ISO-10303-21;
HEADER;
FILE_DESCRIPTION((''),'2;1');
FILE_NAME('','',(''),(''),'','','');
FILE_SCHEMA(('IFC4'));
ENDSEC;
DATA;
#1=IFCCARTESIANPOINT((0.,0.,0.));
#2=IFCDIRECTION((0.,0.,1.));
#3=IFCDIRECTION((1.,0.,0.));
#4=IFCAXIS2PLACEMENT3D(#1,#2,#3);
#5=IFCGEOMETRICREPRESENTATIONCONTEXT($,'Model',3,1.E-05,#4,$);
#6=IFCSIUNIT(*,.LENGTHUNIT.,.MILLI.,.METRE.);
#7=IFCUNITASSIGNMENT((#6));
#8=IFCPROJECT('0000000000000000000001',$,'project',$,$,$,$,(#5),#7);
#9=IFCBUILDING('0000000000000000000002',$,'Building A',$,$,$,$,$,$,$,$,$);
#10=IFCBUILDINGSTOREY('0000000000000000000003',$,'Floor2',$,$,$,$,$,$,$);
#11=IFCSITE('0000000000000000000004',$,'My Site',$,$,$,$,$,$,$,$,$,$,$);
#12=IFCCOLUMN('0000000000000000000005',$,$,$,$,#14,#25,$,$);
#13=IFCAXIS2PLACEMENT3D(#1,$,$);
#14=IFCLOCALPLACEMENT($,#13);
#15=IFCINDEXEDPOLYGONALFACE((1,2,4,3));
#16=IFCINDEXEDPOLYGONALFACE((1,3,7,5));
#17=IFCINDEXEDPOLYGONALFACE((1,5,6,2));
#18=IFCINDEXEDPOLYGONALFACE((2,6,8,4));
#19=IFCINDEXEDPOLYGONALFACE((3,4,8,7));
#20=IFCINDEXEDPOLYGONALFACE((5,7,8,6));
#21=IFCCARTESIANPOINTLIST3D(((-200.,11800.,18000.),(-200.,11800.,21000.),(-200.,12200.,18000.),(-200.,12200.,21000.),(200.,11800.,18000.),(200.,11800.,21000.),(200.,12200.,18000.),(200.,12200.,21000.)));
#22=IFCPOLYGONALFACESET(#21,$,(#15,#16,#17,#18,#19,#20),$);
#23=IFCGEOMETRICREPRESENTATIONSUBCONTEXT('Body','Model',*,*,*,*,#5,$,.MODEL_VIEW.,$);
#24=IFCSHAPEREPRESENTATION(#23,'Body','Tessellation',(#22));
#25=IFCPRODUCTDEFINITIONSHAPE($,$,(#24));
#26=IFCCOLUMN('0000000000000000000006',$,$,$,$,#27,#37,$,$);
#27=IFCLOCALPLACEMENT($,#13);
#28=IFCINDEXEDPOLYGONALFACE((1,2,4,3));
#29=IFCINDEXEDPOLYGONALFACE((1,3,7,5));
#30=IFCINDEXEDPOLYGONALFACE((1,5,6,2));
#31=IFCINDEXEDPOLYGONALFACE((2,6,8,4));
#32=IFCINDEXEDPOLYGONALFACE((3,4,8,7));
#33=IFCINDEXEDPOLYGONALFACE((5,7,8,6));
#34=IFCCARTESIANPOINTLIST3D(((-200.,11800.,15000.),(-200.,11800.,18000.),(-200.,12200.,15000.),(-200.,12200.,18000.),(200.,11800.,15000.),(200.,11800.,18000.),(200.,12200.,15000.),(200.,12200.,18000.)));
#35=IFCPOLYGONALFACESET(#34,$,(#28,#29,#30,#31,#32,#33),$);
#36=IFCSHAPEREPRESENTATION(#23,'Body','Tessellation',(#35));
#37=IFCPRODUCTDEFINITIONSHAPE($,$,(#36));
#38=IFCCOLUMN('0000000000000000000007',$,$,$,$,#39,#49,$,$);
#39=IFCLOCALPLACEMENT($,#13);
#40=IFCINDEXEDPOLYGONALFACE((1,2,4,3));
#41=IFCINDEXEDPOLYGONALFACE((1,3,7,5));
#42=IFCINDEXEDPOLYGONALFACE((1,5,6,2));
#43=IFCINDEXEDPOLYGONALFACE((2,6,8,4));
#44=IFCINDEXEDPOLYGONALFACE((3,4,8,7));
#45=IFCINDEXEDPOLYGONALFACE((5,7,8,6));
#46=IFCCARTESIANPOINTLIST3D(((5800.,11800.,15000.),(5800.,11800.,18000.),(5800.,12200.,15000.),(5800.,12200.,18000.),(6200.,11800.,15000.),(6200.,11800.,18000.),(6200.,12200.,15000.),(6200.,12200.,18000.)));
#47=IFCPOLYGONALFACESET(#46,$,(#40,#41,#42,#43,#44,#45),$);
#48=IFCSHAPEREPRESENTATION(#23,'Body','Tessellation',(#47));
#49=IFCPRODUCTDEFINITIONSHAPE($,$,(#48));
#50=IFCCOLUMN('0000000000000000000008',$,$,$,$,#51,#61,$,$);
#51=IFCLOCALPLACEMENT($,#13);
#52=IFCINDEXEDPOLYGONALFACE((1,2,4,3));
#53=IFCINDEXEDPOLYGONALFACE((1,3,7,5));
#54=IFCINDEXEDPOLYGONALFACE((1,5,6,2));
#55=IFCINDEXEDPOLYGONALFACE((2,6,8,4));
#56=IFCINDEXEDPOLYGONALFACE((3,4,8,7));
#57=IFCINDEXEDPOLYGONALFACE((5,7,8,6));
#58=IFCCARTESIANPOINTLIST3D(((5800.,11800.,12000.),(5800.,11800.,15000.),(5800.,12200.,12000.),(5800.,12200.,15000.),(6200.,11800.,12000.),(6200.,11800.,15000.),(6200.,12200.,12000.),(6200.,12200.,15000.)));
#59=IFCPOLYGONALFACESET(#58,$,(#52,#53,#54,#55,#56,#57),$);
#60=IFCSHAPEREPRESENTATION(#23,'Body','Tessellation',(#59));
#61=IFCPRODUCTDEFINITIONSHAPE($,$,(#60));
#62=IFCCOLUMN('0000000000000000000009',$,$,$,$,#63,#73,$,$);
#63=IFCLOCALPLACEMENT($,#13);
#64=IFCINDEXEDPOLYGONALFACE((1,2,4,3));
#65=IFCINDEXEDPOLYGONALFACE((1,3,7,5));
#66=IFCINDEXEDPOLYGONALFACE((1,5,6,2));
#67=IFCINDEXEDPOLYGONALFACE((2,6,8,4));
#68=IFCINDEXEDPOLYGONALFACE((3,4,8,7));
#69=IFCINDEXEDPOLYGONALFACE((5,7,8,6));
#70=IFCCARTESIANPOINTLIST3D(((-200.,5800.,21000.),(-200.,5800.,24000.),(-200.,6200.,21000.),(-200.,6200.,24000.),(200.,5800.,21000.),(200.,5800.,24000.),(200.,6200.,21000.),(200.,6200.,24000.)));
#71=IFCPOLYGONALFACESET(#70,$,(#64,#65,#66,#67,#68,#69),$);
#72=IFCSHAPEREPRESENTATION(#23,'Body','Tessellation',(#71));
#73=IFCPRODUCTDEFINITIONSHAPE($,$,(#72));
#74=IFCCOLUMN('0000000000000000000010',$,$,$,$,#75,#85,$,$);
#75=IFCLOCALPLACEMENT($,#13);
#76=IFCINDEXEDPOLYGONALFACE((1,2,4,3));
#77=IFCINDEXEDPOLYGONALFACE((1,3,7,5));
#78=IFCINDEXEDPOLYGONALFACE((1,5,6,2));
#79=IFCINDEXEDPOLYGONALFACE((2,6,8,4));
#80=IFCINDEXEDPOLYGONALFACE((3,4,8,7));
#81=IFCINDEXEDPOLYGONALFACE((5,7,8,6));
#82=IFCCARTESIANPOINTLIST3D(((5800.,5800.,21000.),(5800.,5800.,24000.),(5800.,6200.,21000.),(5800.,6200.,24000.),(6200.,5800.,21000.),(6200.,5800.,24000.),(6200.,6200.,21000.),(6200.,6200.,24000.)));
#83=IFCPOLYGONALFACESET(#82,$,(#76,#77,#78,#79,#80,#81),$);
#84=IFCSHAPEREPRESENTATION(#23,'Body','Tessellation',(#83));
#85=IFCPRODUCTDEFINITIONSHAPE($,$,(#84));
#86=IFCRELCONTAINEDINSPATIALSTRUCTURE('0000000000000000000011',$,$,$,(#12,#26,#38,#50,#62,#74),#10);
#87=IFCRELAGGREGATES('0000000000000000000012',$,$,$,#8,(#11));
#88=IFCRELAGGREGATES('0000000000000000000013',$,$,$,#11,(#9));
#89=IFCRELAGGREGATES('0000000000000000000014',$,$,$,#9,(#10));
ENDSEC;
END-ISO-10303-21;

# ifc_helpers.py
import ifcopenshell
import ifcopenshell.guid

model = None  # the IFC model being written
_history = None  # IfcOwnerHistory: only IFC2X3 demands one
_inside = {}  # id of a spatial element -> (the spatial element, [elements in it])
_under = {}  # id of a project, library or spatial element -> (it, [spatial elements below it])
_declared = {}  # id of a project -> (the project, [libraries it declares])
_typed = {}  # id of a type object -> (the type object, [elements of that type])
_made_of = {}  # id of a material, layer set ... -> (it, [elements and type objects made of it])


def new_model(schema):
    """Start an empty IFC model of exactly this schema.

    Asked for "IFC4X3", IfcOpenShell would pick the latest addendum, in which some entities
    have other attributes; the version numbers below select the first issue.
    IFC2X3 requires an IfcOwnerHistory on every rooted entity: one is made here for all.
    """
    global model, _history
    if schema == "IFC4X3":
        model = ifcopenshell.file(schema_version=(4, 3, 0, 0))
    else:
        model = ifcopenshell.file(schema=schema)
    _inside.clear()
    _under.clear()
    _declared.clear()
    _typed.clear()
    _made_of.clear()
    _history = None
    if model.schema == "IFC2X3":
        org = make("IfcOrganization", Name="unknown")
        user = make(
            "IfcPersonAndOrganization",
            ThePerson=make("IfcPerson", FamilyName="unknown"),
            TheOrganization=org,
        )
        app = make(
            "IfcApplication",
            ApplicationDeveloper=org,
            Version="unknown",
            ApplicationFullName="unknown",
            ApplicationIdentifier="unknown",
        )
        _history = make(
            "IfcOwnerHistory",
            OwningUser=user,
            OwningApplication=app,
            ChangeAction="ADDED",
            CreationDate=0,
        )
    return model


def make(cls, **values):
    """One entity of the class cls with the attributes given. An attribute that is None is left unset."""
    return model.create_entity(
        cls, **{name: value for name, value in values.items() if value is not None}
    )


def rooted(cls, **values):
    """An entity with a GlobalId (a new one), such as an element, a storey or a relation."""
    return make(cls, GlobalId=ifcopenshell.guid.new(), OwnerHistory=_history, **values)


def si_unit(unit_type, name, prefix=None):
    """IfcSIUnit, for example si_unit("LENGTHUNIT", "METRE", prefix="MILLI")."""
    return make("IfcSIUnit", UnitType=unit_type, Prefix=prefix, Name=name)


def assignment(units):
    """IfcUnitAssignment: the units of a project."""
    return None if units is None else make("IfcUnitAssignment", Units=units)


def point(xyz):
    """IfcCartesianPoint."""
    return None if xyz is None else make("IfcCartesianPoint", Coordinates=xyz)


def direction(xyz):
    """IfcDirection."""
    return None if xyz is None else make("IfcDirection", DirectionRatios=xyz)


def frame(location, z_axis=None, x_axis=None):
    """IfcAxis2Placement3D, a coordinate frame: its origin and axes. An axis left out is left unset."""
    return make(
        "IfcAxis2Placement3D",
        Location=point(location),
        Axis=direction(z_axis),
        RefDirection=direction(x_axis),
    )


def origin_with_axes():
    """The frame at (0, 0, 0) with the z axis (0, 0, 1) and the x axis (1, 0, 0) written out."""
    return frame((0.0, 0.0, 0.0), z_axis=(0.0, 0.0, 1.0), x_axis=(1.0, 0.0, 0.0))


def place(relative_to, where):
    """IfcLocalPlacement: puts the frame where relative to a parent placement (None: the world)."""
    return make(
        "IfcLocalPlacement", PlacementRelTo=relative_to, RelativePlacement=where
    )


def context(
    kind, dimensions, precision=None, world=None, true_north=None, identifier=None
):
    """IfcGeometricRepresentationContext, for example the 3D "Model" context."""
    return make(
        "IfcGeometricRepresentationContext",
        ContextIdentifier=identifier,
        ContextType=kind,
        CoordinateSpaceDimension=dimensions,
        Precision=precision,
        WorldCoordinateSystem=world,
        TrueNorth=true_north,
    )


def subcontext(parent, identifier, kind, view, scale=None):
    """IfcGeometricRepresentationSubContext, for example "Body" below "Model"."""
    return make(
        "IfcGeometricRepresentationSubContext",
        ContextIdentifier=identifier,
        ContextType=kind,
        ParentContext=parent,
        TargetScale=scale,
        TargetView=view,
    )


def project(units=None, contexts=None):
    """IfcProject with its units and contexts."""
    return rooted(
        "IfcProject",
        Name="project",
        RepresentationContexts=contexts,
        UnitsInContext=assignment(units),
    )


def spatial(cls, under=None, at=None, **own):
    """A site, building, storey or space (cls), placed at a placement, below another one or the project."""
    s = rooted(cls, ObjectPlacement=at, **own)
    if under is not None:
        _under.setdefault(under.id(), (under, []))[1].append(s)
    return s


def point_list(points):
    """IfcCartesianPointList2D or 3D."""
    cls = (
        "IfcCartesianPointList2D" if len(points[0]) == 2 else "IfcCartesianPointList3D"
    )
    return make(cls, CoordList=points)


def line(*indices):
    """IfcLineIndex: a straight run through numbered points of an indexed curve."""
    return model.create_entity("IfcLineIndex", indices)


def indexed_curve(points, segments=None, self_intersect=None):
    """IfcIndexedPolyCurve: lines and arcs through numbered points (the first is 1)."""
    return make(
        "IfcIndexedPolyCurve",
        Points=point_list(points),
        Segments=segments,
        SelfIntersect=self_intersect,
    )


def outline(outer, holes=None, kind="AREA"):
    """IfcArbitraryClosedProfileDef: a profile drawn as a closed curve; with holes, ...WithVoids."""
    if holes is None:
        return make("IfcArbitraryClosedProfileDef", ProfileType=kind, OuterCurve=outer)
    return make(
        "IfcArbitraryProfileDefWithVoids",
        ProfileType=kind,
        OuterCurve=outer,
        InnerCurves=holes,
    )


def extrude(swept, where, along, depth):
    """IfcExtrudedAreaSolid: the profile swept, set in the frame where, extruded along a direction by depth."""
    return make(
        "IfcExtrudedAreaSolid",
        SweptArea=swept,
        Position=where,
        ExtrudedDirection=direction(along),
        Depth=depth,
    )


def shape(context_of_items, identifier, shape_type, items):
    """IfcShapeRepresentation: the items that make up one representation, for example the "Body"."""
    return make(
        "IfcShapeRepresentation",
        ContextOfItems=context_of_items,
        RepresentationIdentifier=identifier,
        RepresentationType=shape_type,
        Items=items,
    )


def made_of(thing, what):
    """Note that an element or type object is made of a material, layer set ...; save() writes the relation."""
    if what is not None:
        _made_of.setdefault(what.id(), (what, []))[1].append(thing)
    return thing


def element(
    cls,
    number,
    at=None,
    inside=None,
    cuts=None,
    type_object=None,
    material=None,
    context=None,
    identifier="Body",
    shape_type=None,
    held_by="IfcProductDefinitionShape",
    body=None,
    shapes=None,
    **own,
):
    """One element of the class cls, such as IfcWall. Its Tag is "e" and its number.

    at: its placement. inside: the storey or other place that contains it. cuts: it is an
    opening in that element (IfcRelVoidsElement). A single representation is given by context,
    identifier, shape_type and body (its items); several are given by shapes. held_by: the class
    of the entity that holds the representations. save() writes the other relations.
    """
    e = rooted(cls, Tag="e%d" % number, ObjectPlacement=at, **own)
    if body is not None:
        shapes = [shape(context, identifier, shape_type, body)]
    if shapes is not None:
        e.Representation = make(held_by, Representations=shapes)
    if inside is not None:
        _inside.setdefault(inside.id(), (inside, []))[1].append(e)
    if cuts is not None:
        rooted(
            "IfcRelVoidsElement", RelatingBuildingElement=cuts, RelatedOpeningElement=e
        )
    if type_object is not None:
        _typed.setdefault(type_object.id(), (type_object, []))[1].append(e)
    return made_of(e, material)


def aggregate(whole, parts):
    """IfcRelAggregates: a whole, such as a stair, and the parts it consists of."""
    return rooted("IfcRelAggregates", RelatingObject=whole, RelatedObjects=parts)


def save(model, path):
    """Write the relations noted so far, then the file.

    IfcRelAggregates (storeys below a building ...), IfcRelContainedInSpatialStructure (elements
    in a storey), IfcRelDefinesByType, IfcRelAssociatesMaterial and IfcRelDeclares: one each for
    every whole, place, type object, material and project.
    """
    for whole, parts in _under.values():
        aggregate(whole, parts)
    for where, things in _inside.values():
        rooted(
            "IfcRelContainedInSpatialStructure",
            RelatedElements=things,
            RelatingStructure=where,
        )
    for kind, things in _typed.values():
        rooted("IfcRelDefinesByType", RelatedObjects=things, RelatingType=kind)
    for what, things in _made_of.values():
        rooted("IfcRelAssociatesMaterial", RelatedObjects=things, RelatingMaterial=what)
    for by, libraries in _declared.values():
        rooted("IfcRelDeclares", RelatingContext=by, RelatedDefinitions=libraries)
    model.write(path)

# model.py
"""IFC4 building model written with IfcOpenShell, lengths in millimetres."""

from ifc_helpers import new_model, si_unit, frame, origin_with_axes, place, context, subcontext, project, spatial, line, indexed_curve, outline, extrude, element, save


model = new_model("IFC4")

# Units and contexts
model_context = context("Model", 3, precision=1e-05, world=origin_with_axes())
body_context = subcontext(model_context, "Body", "Model", "MODEL_VIEW")
ifc_project = project(units=[si_unit("LENGTHUNIT", "METRE", prefix="MILLI")], contexts=[model_context])

# Site, building, storey
site = spatial("IfcSite", under=ifc_project, Name="My Site")
building = spatial("IfcBuilding", under=site, Name="Building A")
storey = spatial("IfcBuildingStorey", under=building, Name="Floor2")

# Columns
for number, where, z_axis, x_axis in (
    (1, (0.0, 12000.0, 18000.0), (0.0, 0.0, 1.0), (1.0, 0.0, 0.0)),
    (2, (0.0, 12000.0, 15000.0), (0.0, 0.0, 1.0), (1.0, 0.0, 0.0)),
    (3, (6000.0, 12000.0, 15000.0), (0.0, 0.0, 1.0), (1.0, 0.0, 0.0)),
    (4, (6000.0, 12000.0, 12000.0), (0.0, 0.0, 1.0), (1.0, 0.0, 0.0)),
    (5, (0.0, 6000.0, 21000.0), (0.0, 0.0, 1.0), (1.0, 0.0, 0.0)),
    (6, (6000.0, 6000.0, 21000.0), (0.0, 0.0, 1.0), (1.0, 0.0, 0.0)),
):
    element("IfcColumn", number, at=place(None, frame(where, z_axis=z_axis, x_axis=x_axis)), inside=storey, context=body_context, shape_type="SweptSolid", body=[
        extrude(outline(indexed_curve([(-200.0, -200.0), (200.0, -200.0), (200.0, 200.0), (-200.0, 200.0)], segments=[line(1, 2, 3, 4, 1)])), origin_with_axes(), (0.0, 0.0, 1.0), 3000.0),
    ])

save(model, "model.ifc")
